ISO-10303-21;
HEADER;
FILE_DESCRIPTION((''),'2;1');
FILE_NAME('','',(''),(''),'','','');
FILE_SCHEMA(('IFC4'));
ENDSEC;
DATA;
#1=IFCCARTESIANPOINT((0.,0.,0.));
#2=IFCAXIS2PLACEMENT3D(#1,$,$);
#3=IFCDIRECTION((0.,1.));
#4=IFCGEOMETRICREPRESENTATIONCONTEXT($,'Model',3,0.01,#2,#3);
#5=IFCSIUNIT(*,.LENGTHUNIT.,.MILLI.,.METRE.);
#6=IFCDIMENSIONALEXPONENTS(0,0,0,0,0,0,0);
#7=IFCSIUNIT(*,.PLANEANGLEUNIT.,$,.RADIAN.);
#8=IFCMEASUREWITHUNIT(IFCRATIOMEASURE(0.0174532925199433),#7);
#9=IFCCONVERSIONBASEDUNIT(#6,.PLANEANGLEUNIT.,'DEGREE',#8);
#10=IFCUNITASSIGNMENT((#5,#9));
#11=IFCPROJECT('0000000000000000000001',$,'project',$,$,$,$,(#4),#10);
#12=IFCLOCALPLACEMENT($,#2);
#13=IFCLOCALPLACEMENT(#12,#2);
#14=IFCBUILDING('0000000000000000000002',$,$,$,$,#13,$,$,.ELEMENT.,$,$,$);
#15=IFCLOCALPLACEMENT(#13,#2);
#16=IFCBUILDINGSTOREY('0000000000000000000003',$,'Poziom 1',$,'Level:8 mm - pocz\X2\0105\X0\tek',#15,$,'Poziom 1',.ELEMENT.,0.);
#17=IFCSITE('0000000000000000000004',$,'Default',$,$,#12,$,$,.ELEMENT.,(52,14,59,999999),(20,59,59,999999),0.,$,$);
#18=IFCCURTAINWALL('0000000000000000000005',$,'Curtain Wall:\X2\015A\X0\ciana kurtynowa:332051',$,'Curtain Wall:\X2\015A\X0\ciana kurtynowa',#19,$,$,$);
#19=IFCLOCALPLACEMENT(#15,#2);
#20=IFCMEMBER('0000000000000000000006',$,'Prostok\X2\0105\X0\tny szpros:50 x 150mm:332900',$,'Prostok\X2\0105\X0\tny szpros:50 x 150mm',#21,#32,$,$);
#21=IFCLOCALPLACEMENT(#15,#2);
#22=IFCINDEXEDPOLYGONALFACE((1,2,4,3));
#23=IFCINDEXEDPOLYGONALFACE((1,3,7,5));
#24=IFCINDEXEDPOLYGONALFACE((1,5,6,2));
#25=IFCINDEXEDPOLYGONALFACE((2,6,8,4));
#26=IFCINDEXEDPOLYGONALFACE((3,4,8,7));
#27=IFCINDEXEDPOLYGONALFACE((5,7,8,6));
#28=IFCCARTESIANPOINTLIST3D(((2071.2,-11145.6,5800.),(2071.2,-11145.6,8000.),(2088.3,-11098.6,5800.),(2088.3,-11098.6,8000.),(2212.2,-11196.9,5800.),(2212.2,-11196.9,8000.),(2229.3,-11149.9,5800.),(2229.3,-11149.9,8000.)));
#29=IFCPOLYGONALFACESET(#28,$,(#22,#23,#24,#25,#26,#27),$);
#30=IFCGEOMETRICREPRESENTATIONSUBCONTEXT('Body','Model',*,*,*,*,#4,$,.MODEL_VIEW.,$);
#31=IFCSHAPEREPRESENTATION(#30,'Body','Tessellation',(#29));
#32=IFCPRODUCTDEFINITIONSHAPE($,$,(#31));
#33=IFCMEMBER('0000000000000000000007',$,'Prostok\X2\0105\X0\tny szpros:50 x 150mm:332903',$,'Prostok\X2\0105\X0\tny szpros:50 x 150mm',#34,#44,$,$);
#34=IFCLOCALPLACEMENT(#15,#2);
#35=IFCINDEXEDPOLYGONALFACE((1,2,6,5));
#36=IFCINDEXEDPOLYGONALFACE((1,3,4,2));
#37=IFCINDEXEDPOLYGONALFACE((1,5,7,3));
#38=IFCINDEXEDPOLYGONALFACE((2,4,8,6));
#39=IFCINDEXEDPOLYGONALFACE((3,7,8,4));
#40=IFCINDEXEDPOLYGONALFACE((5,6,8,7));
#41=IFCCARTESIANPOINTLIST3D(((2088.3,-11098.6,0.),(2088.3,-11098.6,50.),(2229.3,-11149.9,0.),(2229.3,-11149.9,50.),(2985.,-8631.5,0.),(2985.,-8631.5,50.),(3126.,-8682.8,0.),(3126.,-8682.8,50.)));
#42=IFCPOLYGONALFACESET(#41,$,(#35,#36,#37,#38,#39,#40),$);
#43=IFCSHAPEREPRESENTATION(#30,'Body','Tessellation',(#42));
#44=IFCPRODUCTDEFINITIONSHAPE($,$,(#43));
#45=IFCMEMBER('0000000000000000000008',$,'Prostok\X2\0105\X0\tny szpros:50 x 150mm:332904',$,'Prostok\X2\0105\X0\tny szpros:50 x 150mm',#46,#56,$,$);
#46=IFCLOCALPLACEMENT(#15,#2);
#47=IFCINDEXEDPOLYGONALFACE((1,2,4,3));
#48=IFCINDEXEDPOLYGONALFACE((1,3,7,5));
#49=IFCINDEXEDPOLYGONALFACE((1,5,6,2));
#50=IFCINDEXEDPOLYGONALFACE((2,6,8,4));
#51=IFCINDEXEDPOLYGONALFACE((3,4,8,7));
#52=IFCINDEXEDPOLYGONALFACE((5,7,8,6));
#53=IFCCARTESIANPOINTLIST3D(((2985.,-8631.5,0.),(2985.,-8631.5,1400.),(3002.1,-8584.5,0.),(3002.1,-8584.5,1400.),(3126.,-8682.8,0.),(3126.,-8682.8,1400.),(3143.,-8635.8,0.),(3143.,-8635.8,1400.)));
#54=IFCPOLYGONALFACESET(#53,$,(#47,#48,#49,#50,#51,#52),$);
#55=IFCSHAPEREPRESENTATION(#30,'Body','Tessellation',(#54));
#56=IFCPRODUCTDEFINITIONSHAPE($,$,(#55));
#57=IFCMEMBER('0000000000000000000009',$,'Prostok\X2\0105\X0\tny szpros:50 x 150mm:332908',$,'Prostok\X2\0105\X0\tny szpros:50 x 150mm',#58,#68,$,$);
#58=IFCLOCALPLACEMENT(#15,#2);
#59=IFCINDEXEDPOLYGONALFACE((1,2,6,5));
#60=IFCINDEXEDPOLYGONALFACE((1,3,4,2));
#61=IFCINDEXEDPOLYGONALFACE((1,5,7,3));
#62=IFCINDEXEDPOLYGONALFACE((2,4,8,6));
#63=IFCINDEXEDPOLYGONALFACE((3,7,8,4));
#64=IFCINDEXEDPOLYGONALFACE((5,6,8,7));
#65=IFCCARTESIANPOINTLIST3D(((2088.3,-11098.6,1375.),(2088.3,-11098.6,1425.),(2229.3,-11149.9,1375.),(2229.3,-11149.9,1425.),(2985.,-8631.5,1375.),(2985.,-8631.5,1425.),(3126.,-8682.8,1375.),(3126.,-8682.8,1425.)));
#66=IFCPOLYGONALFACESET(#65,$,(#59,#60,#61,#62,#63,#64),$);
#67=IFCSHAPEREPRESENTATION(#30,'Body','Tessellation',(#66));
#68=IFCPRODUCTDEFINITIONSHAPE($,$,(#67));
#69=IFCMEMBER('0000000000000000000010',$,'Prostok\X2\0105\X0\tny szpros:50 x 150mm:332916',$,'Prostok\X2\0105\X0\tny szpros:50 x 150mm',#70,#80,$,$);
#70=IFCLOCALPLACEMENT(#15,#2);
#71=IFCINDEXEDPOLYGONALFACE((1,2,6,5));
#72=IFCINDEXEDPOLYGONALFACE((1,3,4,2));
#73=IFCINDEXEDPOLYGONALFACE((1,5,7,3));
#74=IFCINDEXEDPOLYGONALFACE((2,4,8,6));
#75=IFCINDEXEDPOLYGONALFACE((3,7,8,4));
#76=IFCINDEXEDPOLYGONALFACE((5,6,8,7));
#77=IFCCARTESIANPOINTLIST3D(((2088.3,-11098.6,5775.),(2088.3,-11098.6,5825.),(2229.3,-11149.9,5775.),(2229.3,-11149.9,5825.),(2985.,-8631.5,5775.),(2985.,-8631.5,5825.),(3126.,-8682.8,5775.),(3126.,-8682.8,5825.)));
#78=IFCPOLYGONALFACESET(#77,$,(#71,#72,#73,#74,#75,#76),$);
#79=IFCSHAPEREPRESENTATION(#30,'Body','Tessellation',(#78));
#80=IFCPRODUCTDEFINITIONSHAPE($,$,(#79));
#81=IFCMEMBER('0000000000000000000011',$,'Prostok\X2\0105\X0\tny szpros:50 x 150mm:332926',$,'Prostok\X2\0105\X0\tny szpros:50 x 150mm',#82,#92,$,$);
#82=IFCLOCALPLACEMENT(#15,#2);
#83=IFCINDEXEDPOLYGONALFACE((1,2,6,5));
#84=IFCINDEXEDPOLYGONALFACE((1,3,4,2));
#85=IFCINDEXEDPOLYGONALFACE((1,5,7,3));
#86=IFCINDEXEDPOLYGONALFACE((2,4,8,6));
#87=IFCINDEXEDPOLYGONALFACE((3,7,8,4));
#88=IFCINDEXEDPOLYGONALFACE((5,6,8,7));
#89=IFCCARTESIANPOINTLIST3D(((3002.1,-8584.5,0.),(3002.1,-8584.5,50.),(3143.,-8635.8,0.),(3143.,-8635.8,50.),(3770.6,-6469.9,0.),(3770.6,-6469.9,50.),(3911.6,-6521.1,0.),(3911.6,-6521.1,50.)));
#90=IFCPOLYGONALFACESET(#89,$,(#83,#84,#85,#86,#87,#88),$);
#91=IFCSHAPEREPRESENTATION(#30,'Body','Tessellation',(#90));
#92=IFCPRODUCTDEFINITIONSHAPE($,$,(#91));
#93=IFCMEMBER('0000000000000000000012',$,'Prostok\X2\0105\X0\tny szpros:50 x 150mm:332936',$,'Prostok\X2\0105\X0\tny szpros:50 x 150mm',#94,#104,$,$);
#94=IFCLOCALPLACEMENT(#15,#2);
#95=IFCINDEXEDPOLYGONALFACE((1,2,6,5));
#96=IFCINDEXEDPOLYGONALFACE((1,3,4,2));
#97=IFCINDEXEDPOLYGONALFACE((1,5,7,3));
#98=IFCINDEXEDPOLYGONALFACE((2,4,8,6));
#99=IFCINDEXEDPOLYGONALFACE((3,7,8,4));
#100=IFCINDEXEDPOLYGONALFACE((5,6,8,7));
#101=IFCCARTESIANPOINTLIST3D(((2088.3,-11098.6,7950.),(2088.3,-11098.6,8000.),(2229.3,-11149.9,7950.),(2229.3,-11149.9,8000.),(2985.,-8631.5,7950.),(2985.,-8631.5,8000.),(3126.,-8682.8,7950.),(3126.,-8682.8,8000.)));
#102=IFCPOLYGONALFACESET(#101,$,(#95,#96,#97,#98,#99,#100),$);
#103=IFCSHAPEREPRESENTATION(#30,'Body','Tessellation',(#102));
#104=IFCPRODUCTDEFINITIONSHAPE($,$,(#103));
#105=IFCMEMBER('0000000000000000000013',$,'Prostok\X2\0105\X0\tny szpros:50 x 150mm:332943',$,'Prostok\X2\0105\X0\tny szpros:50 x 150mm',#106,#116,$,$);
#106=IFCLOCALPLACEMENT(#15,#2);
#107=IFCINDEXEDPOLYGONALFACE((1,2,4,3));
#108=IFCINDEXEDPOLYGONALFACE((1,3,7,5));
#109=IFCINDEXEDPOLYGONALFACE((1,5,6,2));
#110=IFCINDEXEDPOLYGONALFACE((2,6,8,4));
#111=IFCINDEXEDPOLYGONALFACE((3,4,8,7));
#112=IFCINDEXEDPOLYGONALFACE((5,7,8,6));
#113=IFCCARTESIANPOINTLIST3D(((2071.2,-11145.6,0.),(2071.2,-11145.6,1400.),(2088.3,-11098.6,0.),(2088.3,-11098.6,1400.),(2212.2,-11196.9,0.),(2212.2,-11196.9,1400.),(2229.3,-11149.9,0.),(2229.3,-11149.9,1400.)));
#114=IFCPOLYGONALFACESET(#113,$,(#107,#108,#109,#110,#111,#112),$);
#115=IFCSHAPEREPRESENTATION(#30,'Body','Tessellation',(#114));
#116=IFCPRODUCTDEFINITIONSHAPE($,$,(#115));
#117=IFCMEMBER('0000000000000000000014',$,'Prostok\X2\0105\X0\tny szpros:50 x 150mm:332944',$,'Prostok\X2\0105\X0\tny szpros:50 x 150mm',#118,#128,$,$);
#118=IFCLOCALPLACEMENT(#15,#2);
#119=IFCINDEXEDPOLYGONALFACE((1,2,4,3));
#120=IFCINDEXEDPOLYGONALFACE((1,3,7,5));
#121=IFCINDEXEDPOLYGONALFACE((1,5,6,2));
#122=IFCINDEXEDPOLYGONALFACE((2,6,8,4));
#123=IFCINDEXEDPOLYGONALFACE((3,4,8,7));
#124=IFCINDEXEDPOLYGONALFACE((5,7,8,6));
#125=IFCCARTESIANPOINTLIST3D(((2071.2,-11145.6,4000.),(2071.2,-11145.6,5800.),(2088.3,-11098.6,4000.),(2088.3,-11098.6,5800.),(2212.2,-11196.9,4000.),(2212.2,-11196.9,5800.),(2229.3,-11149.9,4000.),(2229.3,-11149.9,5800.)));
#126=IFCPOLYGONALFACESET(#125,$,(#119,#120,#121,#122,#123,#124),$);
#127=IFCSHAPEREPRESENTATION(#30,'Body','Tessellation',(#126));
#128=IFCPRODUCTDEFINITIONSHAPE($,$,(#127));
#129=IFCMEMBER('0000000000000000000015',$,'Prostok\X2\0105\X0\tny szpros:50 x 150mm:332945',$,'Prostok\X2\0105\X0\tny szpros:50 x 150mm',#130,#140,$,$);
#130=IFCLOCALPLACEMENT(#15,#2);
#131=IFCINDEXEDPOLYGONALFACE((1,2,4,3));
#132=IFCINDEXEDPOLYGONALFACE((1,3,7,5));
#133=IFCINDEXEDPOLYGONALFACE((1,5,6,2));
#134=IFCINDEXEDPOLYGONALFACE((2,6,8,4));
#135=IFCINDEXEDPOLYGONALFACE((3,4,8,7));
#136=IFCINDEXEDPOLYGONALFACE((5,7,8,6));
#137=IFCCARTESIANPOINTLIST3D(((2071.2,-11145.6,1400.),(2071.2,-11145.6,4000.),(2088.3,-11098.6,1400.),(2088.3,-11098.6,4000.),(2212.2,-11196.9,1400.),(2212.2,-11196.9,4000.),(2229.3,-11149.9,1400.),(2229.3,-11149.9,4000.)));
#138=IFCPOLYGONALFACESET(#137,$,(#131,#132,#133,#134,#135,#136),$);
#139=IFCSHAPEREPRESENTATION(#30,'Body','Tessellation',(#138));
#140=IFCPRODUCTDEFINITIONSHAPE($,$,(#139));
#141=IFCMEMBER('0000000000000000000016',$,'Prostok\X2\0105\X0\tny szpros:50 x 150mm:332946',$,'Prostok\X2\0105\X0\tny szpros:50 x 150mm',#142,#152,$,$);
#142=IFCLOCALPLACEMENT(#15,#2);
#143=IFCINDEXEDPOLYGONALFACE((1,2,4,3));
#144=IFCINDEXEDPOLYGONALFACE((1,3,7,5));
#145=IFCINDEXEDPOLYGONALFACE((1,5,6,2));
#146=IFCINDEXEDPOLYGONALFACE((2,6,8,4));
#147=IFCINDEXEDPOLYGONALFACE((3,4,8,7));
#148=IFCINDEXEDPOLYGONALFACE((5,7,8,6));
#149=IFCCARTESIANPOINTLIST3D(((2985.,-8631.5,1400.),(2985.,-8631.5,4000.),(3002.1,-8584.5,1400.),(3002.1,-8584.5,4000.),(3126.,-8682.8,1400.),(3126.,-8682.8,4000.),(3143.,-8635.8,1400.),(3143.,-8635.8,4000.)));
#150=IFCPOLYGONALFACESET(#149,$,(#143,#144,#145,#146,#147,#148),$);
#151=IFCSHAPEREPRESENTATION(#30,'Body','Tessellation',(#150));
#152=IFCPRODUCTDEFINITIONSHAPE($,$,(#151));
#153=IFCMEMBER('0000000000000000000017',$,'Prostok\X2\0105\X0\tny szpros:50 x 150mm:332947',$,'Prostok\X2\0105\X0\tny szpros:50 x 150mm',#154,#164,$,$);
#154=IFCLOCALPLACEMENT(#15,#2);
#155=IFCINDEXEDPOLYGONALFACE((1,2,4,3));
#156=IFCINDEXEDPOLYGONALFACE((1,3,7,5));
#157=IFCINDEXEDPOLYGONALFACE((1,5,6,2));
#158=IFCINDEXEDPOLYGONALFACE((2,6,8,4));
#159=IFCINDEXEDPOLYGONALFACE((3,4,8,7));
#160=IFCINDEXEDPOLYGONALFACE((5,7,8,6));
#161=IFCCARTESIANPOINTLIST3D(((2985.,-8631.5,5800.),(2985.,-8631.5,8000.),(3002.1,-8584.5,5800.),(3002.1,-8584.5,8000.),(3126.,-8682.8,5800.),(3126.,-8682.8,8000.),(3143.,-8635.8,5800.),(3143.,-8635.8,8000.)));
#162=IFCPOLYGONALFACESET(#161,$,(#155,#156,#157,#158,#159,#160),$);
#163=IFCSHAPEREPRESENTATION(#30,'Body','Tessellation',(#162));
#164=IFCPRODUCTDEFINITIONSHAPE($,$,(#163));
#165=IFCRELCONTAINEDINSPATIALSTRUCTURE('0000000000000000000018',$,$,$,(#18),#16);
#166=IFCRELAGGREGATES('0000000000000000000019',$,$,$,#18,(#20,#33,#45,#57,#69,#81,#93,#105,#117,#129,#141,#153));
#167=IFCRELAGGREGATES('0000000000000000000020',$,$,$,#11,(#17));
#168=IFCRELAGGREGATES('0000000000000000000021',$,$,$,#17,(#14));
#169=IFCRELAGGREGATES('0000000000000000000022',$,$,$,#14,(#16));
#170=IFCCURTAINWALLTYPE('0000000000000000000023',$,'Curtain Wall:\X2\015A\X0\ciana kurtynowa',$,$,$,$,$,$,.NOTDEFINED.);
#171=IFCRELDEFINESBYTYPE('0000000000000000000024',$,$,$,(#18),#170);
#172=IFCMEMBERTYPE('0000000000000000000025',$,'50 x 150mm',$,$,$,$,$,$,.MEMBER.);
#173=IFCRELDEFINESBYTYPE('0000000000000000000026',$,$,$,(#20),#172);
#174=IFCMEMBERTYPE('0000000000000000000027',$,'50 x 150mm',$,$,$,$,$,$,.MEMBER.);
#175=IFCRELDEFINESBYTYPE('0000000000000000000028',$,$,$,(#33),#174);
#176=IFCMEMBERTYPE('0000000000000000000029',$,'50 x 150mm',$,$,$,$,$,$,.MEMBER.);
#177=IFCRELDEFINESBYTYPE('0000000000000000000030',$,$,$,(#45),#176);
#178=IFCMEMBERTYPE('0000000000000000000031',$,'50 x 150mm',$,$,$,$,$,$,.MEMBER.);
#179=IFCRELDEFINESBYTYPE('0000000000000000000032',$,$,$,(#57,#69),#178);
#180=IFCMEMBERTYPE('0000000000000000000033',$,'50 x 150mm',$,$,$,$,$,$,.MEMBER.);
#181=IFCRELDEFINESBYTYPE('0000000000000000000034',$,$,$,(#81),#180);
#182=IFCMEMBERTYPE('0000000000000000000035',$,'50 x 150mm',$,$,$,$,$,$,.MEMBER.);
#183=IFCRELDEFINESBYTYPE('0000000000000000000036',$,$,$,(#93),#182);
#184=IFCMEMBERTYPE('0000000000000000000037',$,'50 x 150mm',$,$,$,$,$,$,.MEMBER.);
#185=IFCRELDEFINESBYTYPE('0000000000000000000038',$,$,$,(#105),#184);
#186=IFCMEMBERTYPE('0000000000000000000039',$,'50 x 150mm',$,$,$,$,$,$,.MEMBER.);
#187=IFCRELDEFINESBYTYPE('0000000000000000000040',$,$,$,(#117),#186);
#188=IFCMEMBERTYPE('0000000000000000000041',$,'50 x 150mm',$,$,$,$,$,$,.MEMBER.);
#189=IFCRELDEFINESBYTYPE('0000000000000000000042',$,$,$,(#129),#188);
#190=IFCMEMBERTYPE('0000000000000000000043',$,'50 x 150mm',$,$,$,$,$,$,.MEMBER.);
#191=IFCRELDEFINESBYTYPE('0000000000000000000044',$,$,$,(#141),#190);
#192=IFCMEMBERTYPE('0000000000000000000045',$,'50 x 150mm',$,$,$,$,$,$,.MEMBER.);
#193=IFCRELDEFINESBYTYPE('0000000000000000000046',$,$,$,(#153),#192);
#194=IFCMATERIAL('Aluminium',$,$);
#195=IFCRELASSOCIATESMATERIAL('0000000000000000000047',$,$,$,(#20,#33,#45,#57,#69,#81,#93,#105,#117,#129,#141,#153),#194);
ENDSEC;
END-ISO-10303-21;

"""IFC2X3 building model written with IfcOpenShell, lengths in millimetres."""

from ifc_helpers import new_model, entity, si_unit, converted_unit, direction, frame, origin, origin_2d_with_axis, place, context, subcontext, project, spatial, rectangle, extrude, source, transform, mapped, material, type_object, type_shapes, element, aggregate, save


model = new_model("IFC2X3")

# Units and contexts
model_context = context("Model", 3, precision=0.01, world=origin(), true_north=direction((0.0, 1.0)))
body_context = subcontext(model_context, "Body", "Model", "MODEL_VIEW")
ifc_project = project(units=[si_unit("LENGTHUNIT", "METRE", prefix="MILLI"), converted_unit("PLANEANGLEUNIT", "DEGREE", entity("IfcRatioMeasure", 0.0174532925199433), si_unit("PLANEANGLEUNIT", "RADIAN"), dimensions=[0, 0, 0, 0, 0, 0, 0])], contexts=[model_context])

# Site, building, storey
site_placement = place(None, origin())
site = spatial("IfcSite", under=ifc_project, at=site_placement, Name="Default", CompositionType="ELEMENT", RefLatitude=(52, 14, 59, 999999), RefLongitude=(20, 59, 59, 999999), RefElevation=0.0)
building_placement = place(site_placement, origin())
building = spatial("IfcBuilding", under=site, at=building_placement, CompositionType="ELEMENT")
storey_placement = place(building_placement, origin())
storey = spatial("IfcBuildingStorey", under=building, at=storey_placement, Name="Poziom 1", ObjectType="Level:8 mm - początek", LongName="Poziom 1", CompositionType="ELEMENT", Elevation=0.0)

# Curtain wall, members
curtain_wall_type = type_object("IfcCurtainWallType", Name="Curtain Wall:Ściana kurtynowa", PredefinedType="NOTDEFINED")
curtain_wall_placement = place(storey_placement, origin())
curtain_wall = element("IfcCurtainWall", 1, at=curtain_wall_placement, inside=storey, type_object=curtain_wall_type, Name="Curtain Wall:Ściana kurtynowa:332051", ObjectType="Curtain Wall:Ściana kurtynowa")
ifc_material_1 = material(Name="Aluminium")
member_type_1 = type_object("IfcMemberType", Name="50 x 150mm", PredefinedType="MEMBER")
shared_shape_1 = source(origin(), body_context, "Body", "SweptSolid", [
    extrude(rectangle(XDim=150.0, YDim=50.0, at=origin_2d_with_axis()), frame((-25.0, 0.0, -2200.0), z_axis=(0.0, 0.0, 1.0), x_axis=(0.0, -1.0, 0.0)), (0.0, 0.0, 1.0), 2200.0),
])
type_shapes(member_type_1, [shared_shape_1])
member_1_placement = place(storey_placement, frame((2141.7, -11171.2, 8000.0), z_axis=(0.0, 0.0, 1.0), x_axis=(-0.341586, -0.939851, 0.0)))
member_1 = element("IfcMember", 2, at=member_1_placement, type_object=member_type_1, material=ifc_material_1, Name="Prostokątny szpros:50 x 150mm:332900", ObjectType="Prostokątny szpros:50 x 150mm", context=body_context, shape_type="MappedRepresentation", body=[
    mapped(shared_shape_1, transform((0.0, 0.0, 0.0), scale=1.0)),
])
member_type_2 = type_object("IfcMemberType", Name="50 x 150mm", PredefinedType="MEMBER")
shared_shape_2 = source(origin(), body_context, "Body", "SweptSolid", [
    extrude(rectangle(XDim=150.0, YDim=50.0, at=origin_2d_with_axis()), frame((-25.0, 0.0, -2625.0), z_axis=(0.0, 0.0, 1.0), x_axis=(0.0, -1.0, 0.0)), (0.0, 0.0, 1.0), 2625.0),
])
type_shapes(member_type_2, [shared_shape_2])
member_2_placement = place(storey_placement, frame((2158.8, -11124.3, 0.0), z_axis=(-0.341586, -0.939851, 0.0), x_axis=(0.0, 0.0, -1.0)))
member_2 = element("IfcMember", 3, at=member_2_placement, type_object=member_type_2, material=ifc_material_1, Name="Prostokątny szpros:50 x 150mm:332903", ObjectType="Prostokątny szpros:50 x 150mm", context=body_context, shape_type="MappedRepresentation", body=[
    mapped(shared_shape_2, transform((0.0, 0.0, 0.0), scale=1.0)),
])
member_type_3 = type_object("IfcMemberType", Name="50 x 150mm", PredefinedType="MEMBER")
shared_shape_3 = source(origin(), body_context, "Body", "SweptSolid", [
    extrude(rectangle(XDim=150.0, YDim=50.0, at=origin_2d_with_axis()), frame((0.0, 0.0, -1400.0), z_axis=(0.0, 0.0, 1.0), x_axis=(0.0, -1.0, 0.0)), (0.0, 0.0, 1.0), 1400.0),
])
type_shapes(member_type_3, [shared_shape_3])
member_3_placement = place(storey_placement, frame((3064.0, -8633.7, 0.0), z_axis=(0.0, 0.0, -1.0), x_axis=(0.341586, 0.939851, 0.0)))
member_3 = element("IfcMember", 4, at=member_3_placement, type_object=member_type_3, material=ifc_material_1, Name="Prostokątny szpros:50 x 150mm:332904", ObjectType="Prostokątny szpros:50 x 150mm", context=body_context, shape_type="MappedRepresentation", body=[
    mapped(shared_shape_3, transform((0.0, 0.0, 0.0), scale=1.0)),
])
member_type_4 = type_object("IfcMemberType", Name="50 x 150mm", PredefinedType="MEMBER")
shared_shape_4 = source(origin(), body_context, "Body", "SweptSolid", [
    extrude(rectangle(XDim=150.0, YDim=50.0, at=origin_2d_with_axis()), frame((0.0, 0.0, -2625.0), z_axis=(0.0, 0.0, 1.0), x_axis=(0.0, -1.0, 0.0)), (0.0, 0.0, 1.0), 2625.0),
])
type_shapes(member_type_4, [shared_shape_4])
member_4_placement = place(storey_placement, frame((3055.5, -8657.1, 1400.0), z_axis=(0.341586, 0.939851, 0.0), x_axis=(0.0, 0.0, 1.0)))
member_4 = element("IfcMember", 5, at=member_4_placement, type_object=member_type_4, material=ifc_material_1, Name="Prostokątny szpros:50 x 150mm:332908", ObjectType="Prostokątny szpros:50 x 150mm", context=body_context, shape_type="MappedRepresentation", body=[
    mapped(shared_shape_4, transform((0.0, 0.0, 0.0), scale=1.0)),
])
member_5_placement = place(storey_placement, frame((3055.5, -8657.1, 5800.0), z_axis=(0.341586, 0.939851, 0.0), x_axis=(0.0, 0.0, 1.0)))
member_5 = element("IfcMember", 6, at=member_5_placement, type_object=member_type_4, material=ifc_material_1, Name="Prostokątny szpros:50 x 150mm:332916", ObjectType="Prostokątny szpros:50 x 150mm", context=body_context, shape_type="MappedRepresentation", body=[
    mapped(shared_shape_4, transform((0.0, 0.0, 0.0), scale=1.0)),
])
member_type_5 = type_object("IfcMemberType", Name="50 x 150mm", PredefinedType="MEMBER")
shared_shape_5 = source(origin(), body_context, "Body", "SweptSolid", [
    extrude(rectangle(XDim=150.0, YDim=50.0, at=origin_2d_with_axis()), frame((-25.0, 0.0, -2250.0), z_axis=(0.0, 0.0, 1.0), x_axis=(0.0, -1.0, 0.0)), (0.0, 0.0, 1.0), 2250.0),
])
type_shapes(member_type_5, [shared_shape_5])
member_6_placement = place(storey_placement, frame((3072.5, -8610.2, 0.0), z_axis=(-0.341586, -0.939851, 0.0), x_axis=(0.0, 0.0, -1.0)))
member_6 = element("IfcMember", 7, at=member_6_placement, type_object=member_type_5, material=ifc_material_1, Name="Prostokątny szpros:50 x 150mm:332926", ObjectType="Prostokątny szpros:50 x 150mm", context=body_context, shape_type="MappedRepresentation", body=[
    mapped(shared_shape_5, transform((0.0, 0.0, 0.0), scale=1.0)),
])
member_type_6 = type_object("IfcMemberType", Name="50 x 150mm", PredefinedType="MEMBER")
shared_shape_6 = source(origin(), body_context, "Body", "SweptSolid", [
    extrude(rectangle(XDim=150.0, YDim=50.0, at=origin_2d_with_axis()), frame((-25.0, 0.0, -2625.0), z_axis=(0.0, 0.0, 1.0), x_axis=(0.0, -1.0, 0.0)), (0.0, 0.0, 1.0), 2625.0),
])
type_shapes(member_type_6, [shared_shape_6])
member_7_placement = place(storey_placement, frame((3055.5, -8657.1, 8000.0), z_axis=(0.341586, 0.939851, 0.0), x_axis=(0.0, 0.0, 1.0)))
member_7 = element("IfcMember", 8, at=member_7_placement, type_object=member_type_6, material=ifc_material_1, Name="Prostokątny szpros:50 x 150mm:332936", ObjectType="Prostokątny szpros:50 x 150mm", context=body_context, shape_type="MappedRepresentation", body=[
    mapped(shared_shape_6, transform((0.0, 0.0, 0.0), scale=1.0)),
])
member_type_7 = type_object("IfcMemberType", Name="50 x 150mm", PredefinedType="MEMBER")
shared_shape_7 = source(origin(), body_context, "Body", "SweptSolid", [
    extrude(rectangle(XDim=150.0, YDim=50.0, at=origin_2d_with_axis()), frame((-25.0, 0.0, -1400.0), z_axis=(0.0, 0.0, 1.0), x_axis=(0.0, -1.0, 0.0)), (0.0, 0.0, 1.0), 1400.0),
])
type_shapes(member_type_7, [shared_shape_7])
member_8_placement = place(storey_placement, frame((2141.7, -11171.2, 1400.0), z_axis=(0.0, 0.0, 1.0), x_axis=(-0.341586, -0.939851, 0.0)))
member_8 = element("IfcMember", 9, at=member_8_placement, type_object=member_type_7, material=ifc_material_1, Name="Prostokątny szpros:50 x 150mm:332943", ObjectType="Prostokątny szpros:50 x 150mm", context=body_context, shape_type="MappedRepresentation", body=[
    mapped(shared_shape_7, transform((0.0, 0.0, 0.0), scale=1.0)),
])
member_type_8 = type_object("IfcMemberType", Name="50 x 150mm", PredefinedType="MEMBER")
shared_shape_8 = source(origin(), body_context, "Body", "SweptSolid", [
    extrude(rectangle(XDim=150.0, YDim=50.0, at=origin_2d_with_axis()), frame((-25.0, 0.0, -1800.0), z_axis=(0.0, 0.0, 1.0), x_axis=(0.0, -1.0, 0.0)), (0.0, 0.0, 1.0), 1800.0),
])
type_shapes(member_type_8, [shared_shape_8])
member_9_placement = place(storey_placement, frame((2141.7, -11171.2, 5800.0), z_axis=(0.0, 0.0, 1.0), x_axis=(-0.341586, -0.939851, 0.0)))
member_9 = element("IfcMember", 10, at=member_9_placement, type_object=member_type_8, material=ifc_material_1, Name="Prostokątny szpros:50 x 150mm:332944", ObjectType="Prostokątny szpros:50 x 150mm", context=body_context, shape_type="MappedRepresentation", body=[
    mapped(shared_shape_8, transform((0.0, 0.0, 0.0), scale=1.0)),
])
member_type_9 = type_object("IfcMemberType", Name="50 x 150mm", PredefinedType="MEMBER")
shared_shape_9 = source(origin(), body_context, "Body", "SweptSolid", [
    extrude(rectangle(XDim=150.0, YDim=50.0, at=origin_2d_with_axis()), frame((-25.0, 0.0, -2600.0), z_axis=(0.0, 0.0, 1.0), x_axis=(0.0, -1.0, 0.0)), (0.0, 0.0, 1.0), 2600.0),
])
type_shapes(member_type_9, [shared_shape_9])
member_10_placement = place(storey_placement, frame((2141.7, -11171.2, 4000.0), z_axis=(0.0, 0.0, 1.0), x_axis=(-0.341586, -0.939851, 0.0)))
member_10 = element("IfcMember", 11, at=member_10_placement, type_object=member_type_9, material=ifc_material_1, Name="Prostokątny szpros:50 x 150mm:332945", ObjectType="Prostokątny szpros:50 x 150mm", context=body_context, shape_type="MappedRepresentation", body=[
    mapped(shared_shape_9, transform((0.0, 0.0, 0.0), scale=1.0)),
])
member_type_10 = type_object("IfcMemberType", Name="50 x 150mm", PredefinedType="MEMBER")
shared_shape_10 = source(origin(), body_context, "Body", "SweptSolid", [
    extrude(rectangle(XDim=150.0, YDim=50.0, at=origin_2d_with_axis()), frame((0.0, 0.0, -2600.0), z_axis=(0.0, 0.0, 1.0), x_axis=(0.0, -1.0, 0.0)), (0.0, 0.0, 1.0), 2600.0),
])
type_shapes(member_type_10, [shared_shape_10])
member_11_placement = place(storey_placement, frame((3064.0, -8633.7, 1400.0), z_axis=(0.0, 0.0, -1.0), x_axis=(0.341586, 0.939851, 0.0)))
member_11 = element("IfcMember", 12, at=member_11_placement, type_object=member_type_10, material=ifc_material_1, Name="Prostokątny szpros:50 x 150mm:332946", ObjectType="Prostokątny szpros:50 x 150mm", context=body_context, shape_type="MappedRepresentation", body=[
    mapped(shared_shape_10, transform((0.0, 0.0, 0.0), scale=1.0)),
])
member_type_11 = type_object("IfcMemberType", Name="50 x 150mm", PredefinedType="MEMBER")
shared_shape_11 = source(origin(), body_context, "Body", "SweptSolid", [
    extrude(rectangle(XDim=150.0, YDim=50.0, at=origin_2d_with_axis()), frame((0.0, 0.0, -2200.0), z_axis=(0.0, 0.0, 1.0), x_axis=(0.0, -1.0, 0.0)), (0.0, 0.0, 1.0), 2200.0),
])
type_shapes(member_type_11, [shared_shape_11])
member_12_placement = place(storey_placement, frame((3064.0, -8633.7, 5800.0), z_axis=(0.0, 0.0, -1.0), x_axis=(0.341586, 0.939851, 0.0)))
member_12 = element("IfcMember", 13, at=member_12_placement, type_object=member_type_11, material=ifc_material_1, Name="Prostokątny szpros:50 x 150mm:332947", ObjectType="Prostokątny szpros:50 x 150mm", context=body_context, shape_type="MappedRepresentation", body=[
    mapped(shared_shape_11, transform((0.0, 0.0, 0.0), scale=1.0)),
])
aggregate(curtain_wall, [member_1, member_2, member_3, member_4, member_5, member_6, member_7, member_8, member_9, member_10, member_11, member_12])

save(model, "model.ifc")
